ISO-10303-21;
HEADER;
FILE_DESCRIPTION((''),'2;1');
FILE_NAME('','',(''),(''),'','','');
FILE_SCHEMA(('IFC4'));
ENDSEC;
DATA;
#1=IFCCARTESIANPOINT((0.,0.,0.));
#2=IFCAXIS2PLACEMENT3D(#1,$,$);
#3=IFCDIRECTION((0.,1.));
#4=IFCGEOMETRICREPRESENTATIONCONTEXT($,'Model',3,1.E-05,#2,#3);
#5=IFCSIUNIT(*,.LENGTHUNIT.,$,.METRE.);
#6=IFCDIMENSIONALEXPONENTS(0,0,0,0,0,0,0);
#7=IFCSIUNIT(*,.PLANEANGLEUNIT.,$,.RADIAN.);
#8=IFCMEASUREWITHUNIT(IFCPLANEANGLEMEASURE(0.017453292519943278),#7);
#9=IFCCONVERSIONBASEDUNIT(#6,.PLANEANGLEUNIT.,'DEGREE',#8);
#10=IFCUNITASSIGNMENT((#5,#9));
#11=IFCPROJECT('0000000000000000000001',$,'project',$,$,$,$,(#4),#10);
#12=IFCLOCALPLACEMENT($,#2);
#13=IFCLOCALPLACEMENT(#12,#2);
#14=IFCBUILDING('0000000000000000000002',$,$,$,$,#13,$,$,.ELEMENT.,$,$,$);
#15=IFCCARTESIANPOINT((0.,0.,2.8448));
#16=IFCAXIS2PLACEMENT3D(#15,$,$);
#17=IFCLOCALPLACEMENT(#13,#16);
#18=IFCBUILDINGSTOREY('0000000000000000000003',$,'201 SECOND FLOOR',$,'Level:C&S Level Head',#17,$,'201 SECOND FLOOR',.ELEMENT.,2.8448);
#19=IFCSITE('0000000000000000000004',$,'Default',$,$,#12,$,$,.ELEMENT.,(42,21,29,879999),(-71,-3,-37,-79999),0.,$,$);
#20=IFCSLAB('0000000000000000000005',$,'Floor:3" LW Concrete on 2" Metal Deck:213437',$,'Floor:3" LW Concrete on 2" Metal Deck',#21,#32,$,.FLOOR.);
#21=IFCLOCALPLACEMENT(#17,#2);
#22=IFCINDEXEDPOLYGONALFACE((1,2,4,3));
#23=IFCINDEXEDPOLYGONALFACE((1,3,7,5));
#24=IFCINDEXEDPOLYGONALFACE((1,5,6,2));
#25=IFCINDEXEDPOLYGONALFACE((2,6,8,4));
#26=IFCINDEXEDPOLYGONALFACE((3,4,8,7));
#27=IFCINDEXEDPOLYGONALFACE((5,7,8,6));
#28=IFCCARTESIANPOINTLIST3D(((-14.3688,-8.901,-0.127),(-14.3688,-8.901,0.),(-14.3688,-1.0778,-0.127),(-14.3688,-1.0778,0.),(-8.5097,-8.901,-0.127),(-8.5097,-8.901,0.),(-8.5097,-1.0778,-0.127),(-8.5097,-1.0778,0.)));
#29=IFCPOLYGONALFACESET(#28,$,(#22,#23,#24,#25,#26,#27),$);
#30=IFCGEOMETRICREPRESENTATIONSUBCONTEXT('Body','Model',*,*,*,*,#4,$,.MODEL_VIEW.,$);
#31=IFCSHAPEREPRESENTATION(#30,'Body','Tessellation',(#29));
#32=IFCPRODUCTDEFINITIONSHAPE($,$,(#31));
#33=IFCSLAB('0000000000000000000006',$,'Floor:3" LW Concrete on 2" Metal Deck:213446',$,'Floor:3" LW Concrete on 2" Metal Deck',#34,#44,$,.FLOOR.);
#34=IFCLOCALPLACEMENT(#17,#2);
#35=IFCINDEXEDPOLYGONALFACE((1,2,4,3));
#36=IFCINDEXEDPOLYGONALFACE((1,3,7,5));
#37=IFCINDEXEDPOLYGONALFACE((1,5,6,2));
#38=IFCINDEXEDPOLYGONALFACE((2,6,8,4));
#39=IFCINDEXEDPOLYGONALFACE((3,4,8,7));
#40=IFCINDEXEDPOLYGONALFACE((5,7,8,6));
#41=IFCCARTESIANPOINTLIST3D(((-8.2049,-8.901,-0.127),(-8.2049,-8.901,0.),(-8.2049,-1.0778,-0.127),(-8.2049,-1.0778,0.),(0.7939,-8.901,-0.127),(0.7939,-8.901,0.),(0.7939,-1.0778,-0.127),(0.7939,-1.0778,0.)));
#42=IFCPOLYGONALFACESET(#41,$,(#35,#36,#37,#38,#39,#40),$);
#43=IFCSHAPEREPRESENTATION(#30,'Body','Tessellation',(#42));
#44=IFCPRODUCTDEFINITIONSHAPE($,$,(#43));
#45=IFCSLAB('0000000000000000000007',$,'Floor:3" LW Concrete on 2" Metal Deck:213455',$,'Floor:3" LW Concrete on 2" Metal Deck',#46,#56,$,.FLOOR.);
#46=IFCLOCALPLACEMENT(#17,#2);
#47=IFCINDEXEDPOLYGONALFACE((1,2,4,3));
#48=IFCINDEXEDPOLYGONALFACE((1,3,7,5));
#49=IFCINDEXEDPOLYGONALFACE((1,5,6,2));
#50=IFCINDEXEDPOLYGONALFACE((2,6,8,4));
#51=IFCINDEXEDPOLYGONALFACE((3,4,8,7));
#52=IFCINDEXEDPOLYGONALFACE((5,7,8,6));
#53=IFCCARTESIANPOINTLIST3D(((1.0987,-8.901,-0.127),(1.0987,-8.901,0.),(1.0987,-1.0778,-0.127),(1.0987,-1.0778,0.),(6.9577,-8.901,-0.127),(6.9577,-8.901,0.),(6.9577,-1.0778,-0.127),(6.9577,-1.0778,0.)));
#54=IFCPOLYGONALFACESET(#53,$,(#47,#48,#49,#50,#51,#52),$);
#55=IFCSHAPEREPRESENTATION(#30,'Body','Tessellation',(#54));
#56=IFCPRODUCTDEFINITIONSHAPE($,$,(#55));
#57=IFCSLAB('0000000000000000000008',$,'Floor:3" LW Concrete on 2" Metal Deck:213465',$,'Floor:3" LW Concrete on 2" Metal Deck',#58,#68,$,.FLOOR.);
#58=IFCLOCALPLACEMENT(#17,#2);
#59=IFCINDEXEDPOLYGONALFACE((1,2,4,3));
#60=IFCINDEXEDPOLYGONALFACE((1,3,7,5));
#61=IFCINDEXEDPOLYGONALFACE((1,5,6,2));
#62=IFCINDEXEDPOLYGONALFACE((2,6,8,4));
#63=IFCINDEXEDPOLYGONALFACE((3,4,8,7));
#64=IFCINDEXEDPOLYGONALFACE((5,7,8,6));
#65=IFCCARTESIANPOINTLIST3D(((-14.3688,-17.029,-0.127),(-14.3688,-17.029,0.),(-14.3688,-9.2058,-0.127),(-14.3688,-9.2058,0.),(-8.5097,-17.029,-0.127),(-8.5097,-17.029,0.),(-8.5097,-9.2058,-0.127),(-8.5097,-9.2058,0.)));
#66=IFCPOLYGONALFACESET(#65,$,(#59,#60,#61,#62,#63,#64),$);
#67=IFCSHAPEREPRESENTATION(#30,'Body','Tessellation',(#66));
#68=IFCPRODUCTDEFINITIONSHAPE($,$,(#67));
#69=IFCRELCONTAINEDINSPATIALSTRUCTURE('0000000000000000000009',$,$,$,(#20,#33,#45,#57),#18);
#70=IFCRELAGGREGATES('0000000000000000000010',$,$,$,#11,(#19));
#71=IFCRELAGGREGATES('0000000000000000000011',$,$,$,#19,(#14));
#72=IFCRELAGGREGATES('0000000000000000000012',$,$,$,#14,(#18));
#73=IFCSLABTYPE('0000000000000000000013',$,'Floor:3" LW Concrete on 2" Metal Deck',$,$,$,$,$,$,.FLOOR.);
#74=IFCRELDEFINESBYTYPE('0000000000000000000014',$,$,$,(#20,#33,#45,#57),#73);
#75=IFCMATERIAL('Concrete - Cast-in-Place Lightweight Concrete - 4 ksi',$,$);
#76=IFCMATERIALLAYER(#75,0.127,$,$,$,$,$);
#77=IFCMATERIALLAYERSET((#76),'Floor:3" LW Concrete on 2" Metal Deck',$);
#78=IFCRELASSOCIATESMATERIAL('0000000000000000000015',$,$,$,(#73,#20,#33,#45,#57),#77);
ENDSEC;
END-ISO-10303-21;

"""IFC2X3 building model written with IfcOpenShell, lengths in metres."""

from ifc_helpers import new_model, entity, si_unit, converted_unit, direction, frame, frame_2d, origin, origin_2d_with_axis, place, context, subcontext, project, spatial, rectangle, extrude, material, layer, layer_set, layer_usage, type_object, element, save


model = new_model("IFC2X3")

# Units and contexts
model_context = context("Model", 3, precision=1e-05, world=origin(), true_north=direction((0.0, 1.0)))
body_context = subcontext(model_context, "Body", "Model", "MODEL_VIEW")
ifc_project = project(units=[si_unit("LENGTHUNIT", "METRE"), converted_unit("PLANEANGLEUNIT", "DEGREE", entity("IfcPlaneAngleMeasure", 0.017453292519943278), si_unit("PLANEANGLEUNIT", "RADIAN"), dimensions=[0, 0, 0, 0, 0, 0, 0])], contexts=[model_context])

# Site, building, storey
site_placement = place(None, origin())
site = spatial("IfcSite", under=ifc_project, at=site_placement, Name="Default", CompositionType="ELEMENT", RefLatitude=(42, 21, 29, 879999), RefLongitude=(-71, -3, -37, -79999), RefElevation=0.0)
building_placement = place(site_placement, origin())
building = spatial("IfcBuilding", under=site, at=building_placement, CompositionType="ELEMENT")
storey_placement = place(building_placement, frame((0.0, 0.0, 2.8448)))
storey = spatial("IfcBuildingStorey", under=building, at=storey_placement, Name="201 SECOND FLOOR", ObjectType="Level:C&S Level Head", LongName="201 SECOND FLOOR", CompositionType="ELEMENT", Elevation=2.8448)

# Slabs
ifc_material_1 = material(Name="Concrete - Cast-in-Place Lightweight Concrete - 4 ksi")
ifc_layer = layer(ifc_material_1, 0.127)
ifc_layer_set = layer_set([ifc_layer], Name="Floor:3\" LW Concrete on 2\" Metal Deck")
slab_type = type_object("IfcSlabType", Name="Floor:3\" LW Concrete on 2\" Metal Deck", PredefinedType="FLOOR", material=ifc_layer_set)
ifc_layer_usage_1 = layer_usage(ifc_layer_set, "AXIS3", "POSITIVE", 0.0)
slab_1_placement = place(storey_placement, origin())
element("IfcSlab", 1, at=slab_1_placement, inside=storey, type_object=slab_type, material=ifc_layer_usage_1, Name="Floor:3\" LW Concrete on 2\" Metal Deck:213437", ObjectType="Floor:3\" LW Concrete on 2\" Metal Deck", PredefinedType="FLOOR", context=body_context, shape_type="SweptSolid", body=[
    extrude(rectangle(XDim=7.8232, YDim=5.859, at=origin_2d_with_axis()), frame((-11.4393, -4.9894, 0.0), z_axis=(0.0, 0.0, -1.0), x_axis=(0.0, 1.0, 0.0)), (0.0, 0.0, 1.0), 0.127),
])
ifc_layer_usage_2 = layer_usage(ifc_layer_set, "AXIS3", "POSITIVE", 0.0)
slab_2_placement = place(storey_placement, origin())
element("IfcSlab", 2, at=slab_2_placement, inside=storey, type_object=slab_type, material=ifc_layer_usage_2, Name="Floor:3\" LW Concrete on 2\" Metal Deck:213446", ObjectType="Floor:3\" LW Concrete on 2\" Metal Deck", PredefinedType="FLOOR", context=body_context, shape_type="SweptSolid", body=[
    extrude(rectangle(XDim=7.8232, YDim=8.9988, at=frame_2d((0.0, 0.0), x_axis=(1.0, 0.0))), frame((-3.7055, -4.9894, 0.0), z_axis=(0.0, 0.0, -1.0), x_axis=(0.0, 1.0, 0.0)), (0.0, 0.0, 1.0), 0.127),
])
ifc_layer_usage_3 = layer_usage(ifc_layer_set, "AXIS3", "POSITIVE", 0.0)
slab_3_placement = place(storey_placement, origin())
element("IfcSlab", 3, at=slab_3_placement, inside=storey, type_object=slab_type, material=ifc_layer_usage_3, Name="Floor:3\" LW Concrete on 2\" Metal Deck:213455", ObjectType="Floor:3\" LW Concrete on 2\" Metal Deck", PredefinedType="FLOOR", context=body_context, shape_type="SweptSolid", body=[
    extrude(rectangle(XDim=7.8232, YDim=5.859, at=origin_2d_with_axis()), frame((4.0282, -4.9894, 0.0), z_axis=(0.0, 0.0, -1.0), x_axis=(0.0, 1.0, 0.0)), (0.0, 0.0, 1.0), 0.127),
])
ifc_layer_usage_4 = layer_usage(ifc_layer_set, "AXIS3", "POSITIVE", 0.0)
slab_4_placement = place(storey_placement, origin())
element("IfcSlab", 4, at=slab_4_placement, inside=storey, type_object=slab_type, material=ifc_layer_usage_4, Name="Floor:3\" LW Concrete on 2\" Metal Deck:213465", ObjectType="Floor:3\" LW Concrete on 2\" Metal Deck", PredefinedType="FLOOR", context=body_context, shape_type="SweptSolid", body=[
    extrude(rectangle(XDim=7.8232, YDim=5.859, at=frame_2d((0.0, 0.0), x_axis=(1.0, 0.0))), frame((-11.4393, -13.1174, 0.0), z_axis=(0.0, 0.0, -1.0), x_axis=(0.0, 1.0, 0.0)), (0.0, 0.0, 1.0), 0.127),
])

save(model, "model.ifc")
